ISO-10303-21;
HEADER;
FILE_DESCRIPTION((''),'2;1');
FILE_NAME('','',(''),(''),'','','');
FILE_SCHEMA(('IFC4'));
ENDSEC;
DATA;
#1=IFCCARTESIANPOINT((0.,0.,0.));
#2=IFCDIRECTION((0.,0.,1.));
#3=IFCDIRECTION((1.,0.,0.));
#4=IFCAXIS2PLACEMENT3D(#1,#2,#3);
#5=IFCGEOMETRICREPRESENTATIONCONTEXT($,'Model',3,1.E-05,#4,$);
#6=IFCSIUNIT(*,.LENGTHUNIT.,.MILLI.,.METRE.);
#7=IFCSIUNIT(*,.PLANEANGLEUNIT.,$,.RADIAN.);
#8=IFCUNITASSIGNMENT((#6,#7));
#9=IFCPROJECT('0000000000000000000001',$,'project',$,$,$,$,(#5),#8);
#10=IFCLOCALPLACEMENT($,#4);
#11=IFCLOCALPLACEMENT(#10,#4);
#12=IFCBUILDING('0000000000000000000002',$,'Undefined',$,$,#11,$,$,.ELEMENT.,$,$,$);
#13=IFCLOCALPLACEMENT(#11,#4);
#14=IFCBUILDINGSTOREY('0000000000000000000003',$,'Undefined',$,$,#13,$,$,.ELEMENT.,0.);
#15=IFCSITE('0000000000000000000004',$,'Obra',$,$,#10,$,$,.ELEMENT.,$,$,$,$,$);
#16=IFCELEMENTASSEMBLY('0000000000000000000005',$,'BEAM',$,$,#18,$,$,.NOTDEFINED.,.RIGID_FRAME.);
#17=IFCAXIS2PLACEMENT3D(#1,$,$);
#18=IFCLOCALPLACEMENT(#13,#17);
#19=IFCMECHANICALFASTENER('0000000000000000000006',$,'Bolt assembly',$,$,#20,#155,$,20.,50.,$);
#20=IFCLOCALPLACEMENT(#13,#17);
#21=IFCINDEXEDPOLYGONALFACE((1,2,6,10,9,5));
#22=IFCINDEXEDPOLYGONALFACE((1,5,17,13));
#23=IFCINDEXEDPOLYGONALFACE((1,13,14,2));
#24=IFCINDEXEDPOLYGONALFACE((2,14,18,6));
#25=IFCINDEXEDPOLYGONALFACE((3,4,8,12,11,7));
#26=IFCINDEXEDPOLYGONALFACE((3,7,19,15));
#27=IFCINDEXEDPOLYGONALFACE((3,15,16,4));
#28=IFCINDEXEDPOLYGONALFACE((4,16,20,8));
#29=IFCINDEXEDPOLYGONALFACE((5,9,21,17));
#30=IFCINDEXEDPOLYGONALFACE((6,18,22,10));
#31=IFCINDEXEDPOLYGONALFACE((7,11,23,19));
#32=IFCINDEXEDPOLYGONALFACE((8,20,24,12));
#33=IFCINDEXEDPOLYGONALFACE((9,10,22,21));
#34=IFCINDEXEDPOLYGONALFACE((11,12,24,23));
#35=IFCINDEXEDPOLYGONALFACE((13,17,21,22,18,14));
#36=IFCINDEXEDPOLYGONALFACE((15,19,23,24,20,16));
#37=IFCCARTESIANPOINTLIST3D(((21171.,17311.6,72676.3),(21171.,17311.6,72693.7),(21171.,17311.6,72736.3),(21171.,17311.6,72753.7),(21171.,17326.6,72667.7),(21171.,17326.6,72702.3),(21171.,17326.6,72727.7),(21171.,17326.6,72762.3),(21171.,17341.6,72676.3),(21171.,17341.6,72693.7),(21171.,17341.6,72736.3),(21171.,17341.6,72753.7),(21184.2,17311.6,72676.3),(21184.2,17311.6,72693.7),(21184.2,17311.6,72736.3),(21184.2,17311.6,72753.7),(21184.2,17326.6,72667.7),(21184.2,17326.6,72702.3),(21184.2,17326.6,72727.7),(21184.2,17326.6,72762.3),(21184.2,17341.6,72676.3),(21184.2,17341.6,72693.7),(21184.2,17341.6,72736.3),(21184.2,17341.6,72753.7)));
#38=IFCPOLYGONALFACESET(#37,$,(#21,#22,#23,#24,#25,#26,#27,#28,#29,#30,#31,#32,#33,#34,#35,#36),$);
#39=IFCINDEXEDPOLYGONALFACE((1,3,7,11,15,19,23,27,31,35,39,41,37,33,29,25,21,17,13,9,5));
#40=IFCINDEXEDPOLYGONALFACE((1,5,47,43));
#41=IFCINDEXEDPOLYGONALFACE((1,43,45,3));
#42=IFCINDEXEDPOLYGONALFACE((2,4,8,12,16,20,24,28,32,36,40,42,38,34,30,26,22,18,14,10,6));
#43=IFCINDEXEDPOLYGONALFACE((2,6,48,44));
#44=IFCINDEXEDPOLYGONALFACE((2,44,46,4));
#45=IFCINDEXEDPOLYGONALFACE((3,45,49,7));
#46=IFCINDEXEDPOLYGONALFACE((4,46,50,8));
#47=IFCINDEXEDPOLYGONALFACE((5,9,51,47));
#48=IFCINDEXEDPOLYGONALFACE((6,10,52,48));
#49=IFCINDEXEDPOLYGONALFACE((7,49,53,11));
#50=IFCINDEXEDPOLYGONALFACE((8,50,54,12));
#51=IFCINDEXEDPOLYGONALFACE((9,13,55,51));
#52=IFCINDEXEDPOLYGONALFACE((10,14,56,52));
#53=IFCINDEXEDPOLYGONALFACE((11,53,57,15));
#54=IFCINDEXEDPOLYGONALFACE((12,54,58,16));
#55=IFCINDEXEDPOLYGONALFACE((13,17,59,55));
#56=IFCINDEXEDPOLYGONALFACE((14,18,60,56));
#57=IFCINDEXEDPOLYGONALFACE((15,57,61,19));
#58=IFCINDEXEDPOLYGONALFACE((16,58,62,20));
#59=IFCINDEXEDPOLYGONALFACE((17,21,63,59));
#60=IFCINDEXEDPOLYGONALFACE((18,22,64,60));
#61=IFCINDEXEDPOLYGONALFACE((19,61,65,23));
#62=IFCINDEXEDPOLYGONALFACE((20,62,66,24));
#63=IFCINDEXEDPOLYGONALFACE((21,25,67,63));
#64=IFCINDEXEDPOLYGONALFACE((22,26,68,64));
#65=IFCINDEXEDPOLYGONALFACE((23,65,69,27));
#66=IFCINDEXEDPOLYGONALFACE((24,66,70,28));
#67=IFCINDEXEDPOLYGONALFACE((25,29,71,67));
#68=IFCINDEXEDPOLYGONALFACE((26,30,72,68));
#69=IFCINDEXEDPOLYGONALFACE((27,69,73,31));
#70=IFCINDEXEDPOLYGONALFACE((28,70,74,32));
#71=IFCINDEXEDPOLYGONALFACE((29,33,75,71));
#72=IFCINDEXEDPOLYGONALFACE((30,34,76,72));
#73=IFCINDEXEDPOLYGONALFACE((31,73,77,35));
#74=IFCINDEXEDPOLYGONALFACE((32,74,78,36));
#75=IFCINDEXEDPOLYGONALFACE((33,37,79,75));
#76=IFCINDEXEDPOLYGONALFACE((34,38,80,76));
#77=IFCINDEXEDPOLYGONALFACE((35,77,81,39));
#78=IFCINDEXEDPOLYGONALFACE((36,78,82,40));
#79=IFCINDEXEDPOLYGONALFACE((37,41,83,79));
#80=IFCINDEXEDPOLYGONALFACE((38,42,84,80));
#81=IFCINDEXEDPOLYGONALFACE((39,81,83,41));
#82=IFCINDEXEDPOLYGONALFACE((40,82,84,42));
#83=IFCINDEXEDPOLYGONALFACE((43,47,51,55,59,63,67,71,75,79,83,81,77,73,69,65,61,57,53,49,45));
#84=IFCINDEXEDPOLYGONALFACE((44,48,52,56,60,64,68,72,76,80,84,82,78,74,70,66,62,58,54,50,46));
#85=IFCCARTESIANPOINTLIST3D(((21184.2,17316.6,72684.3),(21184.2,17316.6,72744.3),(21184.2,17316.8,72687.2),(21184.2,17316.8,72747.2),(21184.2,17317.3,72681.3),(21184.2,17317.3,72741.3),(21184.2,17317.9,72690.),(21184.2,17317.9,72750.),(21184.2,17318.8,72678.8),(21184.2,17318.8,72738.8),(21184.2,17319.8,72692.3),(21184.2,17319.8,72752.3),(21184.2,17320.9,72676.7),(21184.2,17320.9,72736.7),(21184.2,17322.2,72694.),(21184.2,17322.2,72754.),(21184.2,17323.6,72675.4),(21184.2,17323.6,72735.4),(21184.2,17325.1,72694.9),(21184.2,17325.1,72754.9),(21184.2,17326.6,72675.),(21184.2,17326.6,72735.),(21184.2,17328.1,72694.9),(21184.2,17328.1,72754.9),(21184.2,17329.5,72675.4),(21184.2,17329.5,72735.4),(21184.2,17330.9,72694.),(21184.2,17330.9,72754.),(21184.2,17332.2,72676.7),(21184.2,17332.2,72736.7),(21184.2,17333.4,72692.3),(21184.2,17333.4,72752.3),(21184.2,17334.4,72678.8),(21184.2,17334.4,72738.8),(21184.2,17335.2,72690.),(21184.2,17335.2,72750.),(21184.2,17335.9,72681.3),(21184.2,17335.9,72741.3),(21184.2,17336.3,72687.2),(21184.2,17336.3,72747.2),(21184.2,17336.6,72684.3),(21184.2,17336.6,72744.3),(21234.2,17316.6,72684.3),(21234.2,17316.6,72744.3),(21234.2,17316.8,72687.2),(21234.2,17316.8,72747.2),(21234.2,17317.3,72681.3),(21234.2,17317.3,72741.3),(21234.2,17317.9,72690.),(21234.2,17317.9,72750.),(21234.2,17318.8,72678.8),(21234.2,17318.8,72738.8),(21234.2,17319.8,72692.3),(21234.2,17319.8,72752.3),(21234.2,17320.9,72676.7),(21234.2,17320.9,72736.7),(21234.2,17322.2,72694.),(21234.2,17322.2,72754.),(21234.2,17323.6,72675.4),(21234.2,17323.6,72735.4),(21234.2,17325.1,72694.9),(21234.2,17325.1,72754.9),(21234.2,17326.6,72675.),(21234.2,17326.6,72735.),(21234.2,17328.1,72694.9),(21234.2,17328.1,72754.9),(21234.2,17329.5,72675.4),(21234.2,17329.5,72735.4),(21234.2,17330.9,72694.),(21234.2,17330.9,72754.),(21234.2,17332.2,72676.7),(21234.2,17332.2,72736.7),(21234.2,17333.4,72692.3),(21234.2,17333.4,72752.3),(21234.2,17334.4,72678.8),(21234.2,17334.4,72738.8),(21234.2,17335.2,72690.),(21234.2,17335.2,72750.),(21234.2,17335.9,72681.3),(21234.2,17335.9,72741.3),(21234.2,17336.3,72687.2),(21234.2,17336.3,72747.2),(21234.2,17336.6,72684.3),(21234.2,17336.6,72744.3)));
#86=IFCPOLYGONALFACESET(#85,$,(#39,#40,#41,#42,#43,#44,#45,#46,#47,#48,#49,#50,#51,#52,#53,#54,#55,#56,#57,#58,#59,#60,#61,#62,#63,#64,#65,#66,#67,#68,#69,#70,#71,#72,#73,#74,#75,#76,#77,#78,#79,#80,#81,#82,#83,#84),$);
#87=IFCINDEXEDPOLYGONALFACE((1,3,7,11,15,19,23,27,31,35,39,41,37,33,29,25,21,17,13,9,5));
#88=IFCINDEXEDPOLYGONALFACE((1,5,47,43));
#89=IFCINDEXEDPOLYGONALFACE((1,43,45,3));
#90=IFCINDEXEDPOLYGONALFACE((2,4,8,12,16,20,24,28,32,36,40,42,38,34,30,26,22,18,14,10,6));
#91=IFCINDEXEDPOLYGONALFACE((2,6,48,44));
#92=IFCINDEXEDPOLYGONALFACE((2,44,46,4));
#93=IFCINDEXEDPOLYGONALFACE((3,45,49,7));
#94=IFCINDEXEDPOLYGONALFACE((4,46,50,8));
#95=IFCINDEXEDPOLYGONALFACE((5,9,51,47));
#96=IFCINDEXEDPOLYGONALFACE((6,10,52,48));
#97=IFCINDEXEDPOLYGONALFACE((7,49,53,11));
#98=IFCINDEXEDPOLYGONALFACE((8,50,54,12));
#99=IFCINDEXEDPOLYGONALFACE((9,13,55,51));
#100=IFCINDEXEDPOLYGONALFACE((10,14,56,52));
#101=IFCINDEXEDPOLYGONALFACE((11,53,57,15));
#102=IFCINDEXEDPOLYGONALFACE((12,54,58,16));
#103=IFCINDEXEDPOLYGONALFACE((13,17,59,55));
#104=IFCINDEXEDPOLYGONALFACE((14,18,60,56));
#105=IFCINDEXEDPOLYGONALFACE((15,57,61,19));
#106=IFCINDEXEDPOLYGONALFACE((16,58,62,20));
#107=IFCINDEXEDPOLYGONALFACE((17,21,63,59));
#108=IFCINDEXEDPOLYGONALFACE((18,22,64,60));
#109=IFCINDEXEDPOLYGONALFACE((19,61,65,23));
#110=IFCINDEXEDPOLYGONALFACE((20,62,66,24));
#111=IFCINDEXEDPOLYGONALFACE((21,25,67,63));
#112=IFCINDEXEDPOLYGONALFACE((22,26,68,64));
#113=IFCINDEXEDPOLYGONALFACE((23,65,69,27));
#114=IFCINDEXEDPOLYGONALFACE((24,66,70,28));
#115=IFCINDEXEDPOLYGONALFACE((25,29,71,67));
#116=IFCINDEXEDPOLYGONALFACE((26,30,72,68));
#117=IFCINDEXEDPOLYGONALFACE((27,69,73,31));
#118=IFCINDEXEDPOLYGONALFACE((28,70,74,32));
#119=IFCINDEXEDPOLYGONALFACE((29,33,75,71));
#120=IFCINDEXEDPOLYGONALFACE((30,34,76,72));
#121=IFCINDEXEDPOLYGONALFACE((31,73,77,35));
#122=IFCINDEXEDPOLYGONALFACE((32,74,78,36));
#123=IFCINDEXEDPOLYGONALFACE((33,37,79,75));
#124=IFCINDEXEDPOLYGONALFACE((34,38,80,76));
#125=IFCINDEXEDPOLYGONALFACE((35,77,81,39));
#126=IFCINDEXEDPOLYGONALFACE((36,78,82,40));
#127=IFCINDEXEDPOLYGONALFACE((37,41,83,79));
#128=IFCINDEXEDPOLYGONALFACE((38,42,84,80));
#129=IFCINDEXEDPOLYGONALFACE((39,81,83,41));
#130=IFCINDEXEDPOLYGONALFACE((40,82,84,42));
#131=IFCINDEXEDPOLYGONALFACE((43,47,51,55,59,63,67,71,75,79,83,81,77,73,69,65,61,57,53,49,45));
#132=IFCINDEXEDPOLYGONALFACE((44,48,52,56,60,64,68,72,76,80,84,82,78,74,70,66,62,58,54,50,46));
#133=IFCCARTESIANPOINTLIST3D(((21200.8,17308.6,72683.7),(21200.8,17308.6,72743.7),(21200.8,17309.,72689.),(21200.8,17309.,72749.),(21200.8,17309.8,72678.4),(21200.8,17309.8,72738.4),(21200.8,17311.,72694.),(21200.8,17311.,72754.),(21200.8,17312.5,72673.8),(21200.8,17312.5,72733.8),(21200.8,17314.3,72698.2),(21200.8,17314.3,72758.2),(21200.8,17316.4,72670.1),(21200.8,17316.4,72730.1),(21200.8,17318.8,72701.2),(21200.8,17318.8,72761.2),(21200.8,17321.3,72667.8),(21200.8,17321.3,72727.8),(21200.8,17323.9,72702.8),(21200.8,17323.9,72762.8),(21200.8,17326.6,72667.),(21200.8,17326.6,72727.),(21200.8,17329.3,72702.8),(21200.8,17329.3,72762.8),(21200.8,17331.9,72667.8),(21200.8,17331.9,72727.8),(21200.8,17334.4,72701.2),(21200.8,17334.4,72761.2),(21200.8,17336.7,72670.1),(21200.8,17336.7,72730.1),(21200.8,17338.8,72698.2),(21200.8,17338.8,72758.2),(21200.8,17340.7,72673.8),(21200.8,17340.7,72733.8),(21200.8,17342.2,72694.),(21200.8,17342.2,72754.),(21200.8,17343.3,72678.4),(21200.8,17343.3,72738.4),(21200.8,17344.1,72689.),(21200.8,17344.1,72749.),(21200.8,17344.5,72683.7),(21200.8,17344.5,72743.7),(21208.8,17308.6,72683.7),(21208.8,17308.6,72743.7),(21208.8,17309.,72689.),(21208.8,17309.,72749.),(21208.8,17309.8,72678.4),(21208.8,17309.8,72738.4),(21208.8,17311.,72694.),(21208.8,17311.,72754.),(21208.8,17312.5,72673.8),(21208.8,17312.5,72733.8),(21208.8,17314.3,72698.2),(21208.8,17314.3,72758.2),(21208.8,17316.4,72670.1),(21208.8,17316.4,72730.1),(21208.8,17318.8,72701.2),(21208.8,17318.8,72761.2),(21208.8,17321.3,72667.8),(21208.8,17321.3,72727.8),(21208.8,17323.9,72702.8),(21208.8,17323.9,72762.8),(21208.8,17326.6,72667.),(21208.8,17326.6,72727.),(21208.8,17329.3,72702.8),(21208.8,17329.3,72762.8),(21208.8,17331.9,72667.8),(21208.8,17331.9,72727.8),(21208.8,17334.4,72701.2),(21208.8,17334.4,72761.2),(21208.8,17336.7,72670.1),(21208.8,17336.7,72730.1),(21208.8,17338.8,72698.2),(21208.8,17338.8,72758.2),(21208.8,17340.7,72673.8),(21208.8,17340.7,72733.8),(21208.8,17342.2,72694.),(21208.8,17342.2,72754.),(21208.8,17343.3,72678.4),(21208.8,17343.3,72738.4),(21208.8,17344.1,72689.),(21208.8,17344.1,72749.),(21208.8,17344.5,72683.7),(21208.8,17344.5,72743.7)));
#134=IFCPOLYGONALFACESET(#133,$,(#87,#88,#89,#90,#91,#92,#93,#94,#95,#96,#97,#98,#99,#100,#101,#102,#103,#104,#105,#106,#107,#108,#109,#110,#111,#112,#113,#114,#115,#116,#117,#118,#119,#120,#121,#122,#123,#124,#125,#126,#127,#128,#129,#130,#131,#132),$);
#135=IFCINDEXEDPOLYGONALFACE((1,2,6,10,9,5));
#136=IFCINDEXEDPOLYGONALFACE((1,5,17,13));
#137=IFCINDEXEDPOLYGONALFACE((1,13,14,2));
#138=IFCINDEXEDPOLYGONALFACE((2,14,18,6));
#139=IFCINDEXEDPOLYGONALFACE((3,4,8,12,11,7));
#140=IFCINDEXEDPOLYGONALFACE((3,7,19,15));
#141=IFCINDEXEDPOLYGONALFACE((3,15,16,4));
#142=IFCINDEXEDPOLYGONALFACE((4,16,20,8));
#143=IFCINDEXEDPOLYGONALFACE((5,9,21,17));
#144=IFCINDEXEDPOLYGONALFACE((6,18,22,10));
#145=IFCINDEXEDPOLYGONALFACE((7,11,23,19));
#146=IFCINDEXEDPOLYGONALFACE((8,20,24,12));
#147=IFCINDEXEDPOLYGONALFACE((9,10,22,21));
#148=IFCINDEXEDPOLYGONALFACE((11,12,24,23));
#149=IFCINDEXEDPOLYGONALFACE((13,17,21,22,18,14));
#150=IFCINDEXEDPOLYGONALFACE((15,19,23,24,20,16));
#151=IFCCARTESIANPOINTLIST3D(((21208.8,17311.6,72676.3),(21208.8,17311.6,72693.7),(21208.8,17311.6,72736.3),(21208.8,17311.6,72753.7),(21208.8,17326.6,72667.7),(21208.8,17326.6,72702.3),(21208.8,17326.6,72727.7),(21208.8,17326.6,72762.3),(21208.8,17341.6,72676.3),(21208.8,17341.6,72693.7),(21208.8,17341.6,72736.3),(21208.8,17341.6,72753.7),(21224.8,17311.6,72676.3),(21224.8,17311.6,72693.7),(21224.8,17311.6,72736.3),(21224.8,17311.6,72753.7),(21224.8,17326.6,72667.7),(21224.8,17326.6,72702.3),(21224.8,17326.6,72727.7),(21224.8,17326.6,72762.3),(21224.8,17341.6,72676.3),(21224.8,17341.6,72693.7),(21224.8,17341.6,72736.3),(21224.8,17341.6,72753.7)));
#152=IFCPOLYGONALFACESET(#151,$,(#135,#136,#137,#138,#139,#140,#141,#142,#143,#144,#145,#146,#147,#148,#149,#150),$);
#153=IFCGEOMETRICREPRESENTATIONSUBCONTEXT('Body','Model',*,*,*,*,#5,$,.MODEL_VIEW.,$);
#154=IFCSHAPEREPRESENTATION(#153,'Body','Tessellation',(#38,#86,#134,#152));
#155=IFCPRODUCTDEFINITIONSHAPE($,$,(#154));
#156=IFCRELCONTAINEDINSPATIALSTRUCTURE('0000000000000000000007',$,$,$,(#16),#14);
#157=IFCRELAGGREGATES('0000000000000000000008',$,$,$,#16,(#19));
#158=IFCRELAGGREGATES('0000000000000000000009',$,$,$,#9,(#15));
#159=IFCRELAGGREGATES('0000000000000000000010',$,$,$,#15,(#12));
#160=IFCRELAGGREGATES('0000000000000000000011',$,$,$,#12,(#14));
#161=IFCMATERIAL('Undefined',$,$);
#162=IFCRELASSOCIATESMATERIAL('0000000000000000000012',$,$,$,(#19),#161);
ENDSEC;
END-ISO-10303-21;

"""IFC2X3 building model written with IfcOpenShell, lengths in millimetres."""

from ifc_helpers import new_model, si_unit, frame, origin_with_axes, origin_2d_with_axis, place, context, subcontext, project, spatial, polyline, circle, outline, extrude, source, transform, mapped, material, element, aggregate, save


model = new_model("IFC2X3")

# Units and contexts
model_context = context("Model", 3, precision=1e-05, world=origin_with_axes())
body_context = subcontext(model_context, "Body", "Model", "MODEL_VIEW")
ifc_project = project(units=[si_unit("LENGTHUNIT", "METRE", prefix="MILLI"), si_unit("PLANEANGLEUNIT", "RADIAN")], contexts=[model_context])

# Site, building, storey
site_placement = place(None, origin_with_axes())
site = spatial("IfcSite", under=ifc_project, at=site_placement, Name="Obra", CompositionType="ELEMENT")
building_placement = place(site_placement, origin_with_axes())
building = spatial("IfcBuilding", under=site, at=building_placement, Name="Undefined", CompositionType="ELEMENT")
storey_placement = place(building_placement, origin_with_axes())
storey = spatial("IfcBuildingStorey", under=building, at=storey_placement, Name="Undefined", CompositionType="ELEMENT", Elevation=0.0)

# Shared definitions
ifc_material = material(Name="Undefined")

# Element assembly, mechanical fastener
shared_shape_1 = source(origin_with_axes(), body_context, "Body", "SweptSolid", [
    extrude(outline(polyline([(17.3, 0.0), (8.7, 15.0), (-8.7, 15.0), (-17.3, 0.0), (-8.7, -15.0), (8.7, -15.0), (17.3, 0.0)])), frame((0.0, -26.5, 0.0), z_axis=(0.0, 1.0, 0.0), x_axis=(1.0, 0.0, 0.0)), (0.0, 0.0, 1.0), 13.2),
    extrude(circle(Radius=10.0, at=origin_2d_with_axis()), frame((0.0, -13.3, 0.0), z_axis=(0.0, 1.0, 0.0), x_axis=(1.0, 0.0, 0.0)), (0.0, 0.0, 1.0), 50.0),
    extrude(circle(Radius=18.0, at=origin_2d_with_axis()), frame((0.0, 3.3, 0.0), z_axis=(0.0, 1.0, 0.0), x_axis=(1.0, 0.0, 0.0)), (0.0, 0.0, 1.0), 8.0),
    extrude(outline(polyline([(17.3, 0.0), (8.7, 15.0), (-8.7, 15.0), (-17.3, 0.0), (-8.7, -15.0), (8.7, -15.0), (17.3, 0.0)])), frame((0.0, 11.3, 0.0), z_axis=(0.0, 1.0, 0.0), x_axis=(1.0, 0.0, 0.0)), (0.0, 0.0, 1.0), 16.0),
])
assembly_1_placement = place(storey_placement, origin_with_axes())
assembly_1 = element("IfcElementAssembly", 1, at=assembly_1_placement, inside=storey, Name="BEAM", AssemblyPlace="NOTDEFINED", PredefinedType="RIGID_FRAME")
mechanical_fastener_1_placement = place(assembly_1_placement, frame((21197.5, 17366.6, 72850.0), z_axis=(0.0, -1.0, 0.0), x_axis=(0.0, 0.0, -1.0)))
mechanical_fastener_1 = element("IfcMechanicalFastener", 2, at=mechanical_fastener_1_placement, material=ifc_material, Name="Bolt assembly", NominalDiameter=20.0, NominalLength=50.0, context=body_context, shape_type="MappedRepresentation", body=[
    mapped(shared_shape_1, transform((105.0, 0.0, 40.0))),
    mapped(shared_shape_1, transform((165.0, 0.0, 40.0))),
])
aggregate(assembly_1, [mechanical_fastener_1])

save(model, "model.ifc")
